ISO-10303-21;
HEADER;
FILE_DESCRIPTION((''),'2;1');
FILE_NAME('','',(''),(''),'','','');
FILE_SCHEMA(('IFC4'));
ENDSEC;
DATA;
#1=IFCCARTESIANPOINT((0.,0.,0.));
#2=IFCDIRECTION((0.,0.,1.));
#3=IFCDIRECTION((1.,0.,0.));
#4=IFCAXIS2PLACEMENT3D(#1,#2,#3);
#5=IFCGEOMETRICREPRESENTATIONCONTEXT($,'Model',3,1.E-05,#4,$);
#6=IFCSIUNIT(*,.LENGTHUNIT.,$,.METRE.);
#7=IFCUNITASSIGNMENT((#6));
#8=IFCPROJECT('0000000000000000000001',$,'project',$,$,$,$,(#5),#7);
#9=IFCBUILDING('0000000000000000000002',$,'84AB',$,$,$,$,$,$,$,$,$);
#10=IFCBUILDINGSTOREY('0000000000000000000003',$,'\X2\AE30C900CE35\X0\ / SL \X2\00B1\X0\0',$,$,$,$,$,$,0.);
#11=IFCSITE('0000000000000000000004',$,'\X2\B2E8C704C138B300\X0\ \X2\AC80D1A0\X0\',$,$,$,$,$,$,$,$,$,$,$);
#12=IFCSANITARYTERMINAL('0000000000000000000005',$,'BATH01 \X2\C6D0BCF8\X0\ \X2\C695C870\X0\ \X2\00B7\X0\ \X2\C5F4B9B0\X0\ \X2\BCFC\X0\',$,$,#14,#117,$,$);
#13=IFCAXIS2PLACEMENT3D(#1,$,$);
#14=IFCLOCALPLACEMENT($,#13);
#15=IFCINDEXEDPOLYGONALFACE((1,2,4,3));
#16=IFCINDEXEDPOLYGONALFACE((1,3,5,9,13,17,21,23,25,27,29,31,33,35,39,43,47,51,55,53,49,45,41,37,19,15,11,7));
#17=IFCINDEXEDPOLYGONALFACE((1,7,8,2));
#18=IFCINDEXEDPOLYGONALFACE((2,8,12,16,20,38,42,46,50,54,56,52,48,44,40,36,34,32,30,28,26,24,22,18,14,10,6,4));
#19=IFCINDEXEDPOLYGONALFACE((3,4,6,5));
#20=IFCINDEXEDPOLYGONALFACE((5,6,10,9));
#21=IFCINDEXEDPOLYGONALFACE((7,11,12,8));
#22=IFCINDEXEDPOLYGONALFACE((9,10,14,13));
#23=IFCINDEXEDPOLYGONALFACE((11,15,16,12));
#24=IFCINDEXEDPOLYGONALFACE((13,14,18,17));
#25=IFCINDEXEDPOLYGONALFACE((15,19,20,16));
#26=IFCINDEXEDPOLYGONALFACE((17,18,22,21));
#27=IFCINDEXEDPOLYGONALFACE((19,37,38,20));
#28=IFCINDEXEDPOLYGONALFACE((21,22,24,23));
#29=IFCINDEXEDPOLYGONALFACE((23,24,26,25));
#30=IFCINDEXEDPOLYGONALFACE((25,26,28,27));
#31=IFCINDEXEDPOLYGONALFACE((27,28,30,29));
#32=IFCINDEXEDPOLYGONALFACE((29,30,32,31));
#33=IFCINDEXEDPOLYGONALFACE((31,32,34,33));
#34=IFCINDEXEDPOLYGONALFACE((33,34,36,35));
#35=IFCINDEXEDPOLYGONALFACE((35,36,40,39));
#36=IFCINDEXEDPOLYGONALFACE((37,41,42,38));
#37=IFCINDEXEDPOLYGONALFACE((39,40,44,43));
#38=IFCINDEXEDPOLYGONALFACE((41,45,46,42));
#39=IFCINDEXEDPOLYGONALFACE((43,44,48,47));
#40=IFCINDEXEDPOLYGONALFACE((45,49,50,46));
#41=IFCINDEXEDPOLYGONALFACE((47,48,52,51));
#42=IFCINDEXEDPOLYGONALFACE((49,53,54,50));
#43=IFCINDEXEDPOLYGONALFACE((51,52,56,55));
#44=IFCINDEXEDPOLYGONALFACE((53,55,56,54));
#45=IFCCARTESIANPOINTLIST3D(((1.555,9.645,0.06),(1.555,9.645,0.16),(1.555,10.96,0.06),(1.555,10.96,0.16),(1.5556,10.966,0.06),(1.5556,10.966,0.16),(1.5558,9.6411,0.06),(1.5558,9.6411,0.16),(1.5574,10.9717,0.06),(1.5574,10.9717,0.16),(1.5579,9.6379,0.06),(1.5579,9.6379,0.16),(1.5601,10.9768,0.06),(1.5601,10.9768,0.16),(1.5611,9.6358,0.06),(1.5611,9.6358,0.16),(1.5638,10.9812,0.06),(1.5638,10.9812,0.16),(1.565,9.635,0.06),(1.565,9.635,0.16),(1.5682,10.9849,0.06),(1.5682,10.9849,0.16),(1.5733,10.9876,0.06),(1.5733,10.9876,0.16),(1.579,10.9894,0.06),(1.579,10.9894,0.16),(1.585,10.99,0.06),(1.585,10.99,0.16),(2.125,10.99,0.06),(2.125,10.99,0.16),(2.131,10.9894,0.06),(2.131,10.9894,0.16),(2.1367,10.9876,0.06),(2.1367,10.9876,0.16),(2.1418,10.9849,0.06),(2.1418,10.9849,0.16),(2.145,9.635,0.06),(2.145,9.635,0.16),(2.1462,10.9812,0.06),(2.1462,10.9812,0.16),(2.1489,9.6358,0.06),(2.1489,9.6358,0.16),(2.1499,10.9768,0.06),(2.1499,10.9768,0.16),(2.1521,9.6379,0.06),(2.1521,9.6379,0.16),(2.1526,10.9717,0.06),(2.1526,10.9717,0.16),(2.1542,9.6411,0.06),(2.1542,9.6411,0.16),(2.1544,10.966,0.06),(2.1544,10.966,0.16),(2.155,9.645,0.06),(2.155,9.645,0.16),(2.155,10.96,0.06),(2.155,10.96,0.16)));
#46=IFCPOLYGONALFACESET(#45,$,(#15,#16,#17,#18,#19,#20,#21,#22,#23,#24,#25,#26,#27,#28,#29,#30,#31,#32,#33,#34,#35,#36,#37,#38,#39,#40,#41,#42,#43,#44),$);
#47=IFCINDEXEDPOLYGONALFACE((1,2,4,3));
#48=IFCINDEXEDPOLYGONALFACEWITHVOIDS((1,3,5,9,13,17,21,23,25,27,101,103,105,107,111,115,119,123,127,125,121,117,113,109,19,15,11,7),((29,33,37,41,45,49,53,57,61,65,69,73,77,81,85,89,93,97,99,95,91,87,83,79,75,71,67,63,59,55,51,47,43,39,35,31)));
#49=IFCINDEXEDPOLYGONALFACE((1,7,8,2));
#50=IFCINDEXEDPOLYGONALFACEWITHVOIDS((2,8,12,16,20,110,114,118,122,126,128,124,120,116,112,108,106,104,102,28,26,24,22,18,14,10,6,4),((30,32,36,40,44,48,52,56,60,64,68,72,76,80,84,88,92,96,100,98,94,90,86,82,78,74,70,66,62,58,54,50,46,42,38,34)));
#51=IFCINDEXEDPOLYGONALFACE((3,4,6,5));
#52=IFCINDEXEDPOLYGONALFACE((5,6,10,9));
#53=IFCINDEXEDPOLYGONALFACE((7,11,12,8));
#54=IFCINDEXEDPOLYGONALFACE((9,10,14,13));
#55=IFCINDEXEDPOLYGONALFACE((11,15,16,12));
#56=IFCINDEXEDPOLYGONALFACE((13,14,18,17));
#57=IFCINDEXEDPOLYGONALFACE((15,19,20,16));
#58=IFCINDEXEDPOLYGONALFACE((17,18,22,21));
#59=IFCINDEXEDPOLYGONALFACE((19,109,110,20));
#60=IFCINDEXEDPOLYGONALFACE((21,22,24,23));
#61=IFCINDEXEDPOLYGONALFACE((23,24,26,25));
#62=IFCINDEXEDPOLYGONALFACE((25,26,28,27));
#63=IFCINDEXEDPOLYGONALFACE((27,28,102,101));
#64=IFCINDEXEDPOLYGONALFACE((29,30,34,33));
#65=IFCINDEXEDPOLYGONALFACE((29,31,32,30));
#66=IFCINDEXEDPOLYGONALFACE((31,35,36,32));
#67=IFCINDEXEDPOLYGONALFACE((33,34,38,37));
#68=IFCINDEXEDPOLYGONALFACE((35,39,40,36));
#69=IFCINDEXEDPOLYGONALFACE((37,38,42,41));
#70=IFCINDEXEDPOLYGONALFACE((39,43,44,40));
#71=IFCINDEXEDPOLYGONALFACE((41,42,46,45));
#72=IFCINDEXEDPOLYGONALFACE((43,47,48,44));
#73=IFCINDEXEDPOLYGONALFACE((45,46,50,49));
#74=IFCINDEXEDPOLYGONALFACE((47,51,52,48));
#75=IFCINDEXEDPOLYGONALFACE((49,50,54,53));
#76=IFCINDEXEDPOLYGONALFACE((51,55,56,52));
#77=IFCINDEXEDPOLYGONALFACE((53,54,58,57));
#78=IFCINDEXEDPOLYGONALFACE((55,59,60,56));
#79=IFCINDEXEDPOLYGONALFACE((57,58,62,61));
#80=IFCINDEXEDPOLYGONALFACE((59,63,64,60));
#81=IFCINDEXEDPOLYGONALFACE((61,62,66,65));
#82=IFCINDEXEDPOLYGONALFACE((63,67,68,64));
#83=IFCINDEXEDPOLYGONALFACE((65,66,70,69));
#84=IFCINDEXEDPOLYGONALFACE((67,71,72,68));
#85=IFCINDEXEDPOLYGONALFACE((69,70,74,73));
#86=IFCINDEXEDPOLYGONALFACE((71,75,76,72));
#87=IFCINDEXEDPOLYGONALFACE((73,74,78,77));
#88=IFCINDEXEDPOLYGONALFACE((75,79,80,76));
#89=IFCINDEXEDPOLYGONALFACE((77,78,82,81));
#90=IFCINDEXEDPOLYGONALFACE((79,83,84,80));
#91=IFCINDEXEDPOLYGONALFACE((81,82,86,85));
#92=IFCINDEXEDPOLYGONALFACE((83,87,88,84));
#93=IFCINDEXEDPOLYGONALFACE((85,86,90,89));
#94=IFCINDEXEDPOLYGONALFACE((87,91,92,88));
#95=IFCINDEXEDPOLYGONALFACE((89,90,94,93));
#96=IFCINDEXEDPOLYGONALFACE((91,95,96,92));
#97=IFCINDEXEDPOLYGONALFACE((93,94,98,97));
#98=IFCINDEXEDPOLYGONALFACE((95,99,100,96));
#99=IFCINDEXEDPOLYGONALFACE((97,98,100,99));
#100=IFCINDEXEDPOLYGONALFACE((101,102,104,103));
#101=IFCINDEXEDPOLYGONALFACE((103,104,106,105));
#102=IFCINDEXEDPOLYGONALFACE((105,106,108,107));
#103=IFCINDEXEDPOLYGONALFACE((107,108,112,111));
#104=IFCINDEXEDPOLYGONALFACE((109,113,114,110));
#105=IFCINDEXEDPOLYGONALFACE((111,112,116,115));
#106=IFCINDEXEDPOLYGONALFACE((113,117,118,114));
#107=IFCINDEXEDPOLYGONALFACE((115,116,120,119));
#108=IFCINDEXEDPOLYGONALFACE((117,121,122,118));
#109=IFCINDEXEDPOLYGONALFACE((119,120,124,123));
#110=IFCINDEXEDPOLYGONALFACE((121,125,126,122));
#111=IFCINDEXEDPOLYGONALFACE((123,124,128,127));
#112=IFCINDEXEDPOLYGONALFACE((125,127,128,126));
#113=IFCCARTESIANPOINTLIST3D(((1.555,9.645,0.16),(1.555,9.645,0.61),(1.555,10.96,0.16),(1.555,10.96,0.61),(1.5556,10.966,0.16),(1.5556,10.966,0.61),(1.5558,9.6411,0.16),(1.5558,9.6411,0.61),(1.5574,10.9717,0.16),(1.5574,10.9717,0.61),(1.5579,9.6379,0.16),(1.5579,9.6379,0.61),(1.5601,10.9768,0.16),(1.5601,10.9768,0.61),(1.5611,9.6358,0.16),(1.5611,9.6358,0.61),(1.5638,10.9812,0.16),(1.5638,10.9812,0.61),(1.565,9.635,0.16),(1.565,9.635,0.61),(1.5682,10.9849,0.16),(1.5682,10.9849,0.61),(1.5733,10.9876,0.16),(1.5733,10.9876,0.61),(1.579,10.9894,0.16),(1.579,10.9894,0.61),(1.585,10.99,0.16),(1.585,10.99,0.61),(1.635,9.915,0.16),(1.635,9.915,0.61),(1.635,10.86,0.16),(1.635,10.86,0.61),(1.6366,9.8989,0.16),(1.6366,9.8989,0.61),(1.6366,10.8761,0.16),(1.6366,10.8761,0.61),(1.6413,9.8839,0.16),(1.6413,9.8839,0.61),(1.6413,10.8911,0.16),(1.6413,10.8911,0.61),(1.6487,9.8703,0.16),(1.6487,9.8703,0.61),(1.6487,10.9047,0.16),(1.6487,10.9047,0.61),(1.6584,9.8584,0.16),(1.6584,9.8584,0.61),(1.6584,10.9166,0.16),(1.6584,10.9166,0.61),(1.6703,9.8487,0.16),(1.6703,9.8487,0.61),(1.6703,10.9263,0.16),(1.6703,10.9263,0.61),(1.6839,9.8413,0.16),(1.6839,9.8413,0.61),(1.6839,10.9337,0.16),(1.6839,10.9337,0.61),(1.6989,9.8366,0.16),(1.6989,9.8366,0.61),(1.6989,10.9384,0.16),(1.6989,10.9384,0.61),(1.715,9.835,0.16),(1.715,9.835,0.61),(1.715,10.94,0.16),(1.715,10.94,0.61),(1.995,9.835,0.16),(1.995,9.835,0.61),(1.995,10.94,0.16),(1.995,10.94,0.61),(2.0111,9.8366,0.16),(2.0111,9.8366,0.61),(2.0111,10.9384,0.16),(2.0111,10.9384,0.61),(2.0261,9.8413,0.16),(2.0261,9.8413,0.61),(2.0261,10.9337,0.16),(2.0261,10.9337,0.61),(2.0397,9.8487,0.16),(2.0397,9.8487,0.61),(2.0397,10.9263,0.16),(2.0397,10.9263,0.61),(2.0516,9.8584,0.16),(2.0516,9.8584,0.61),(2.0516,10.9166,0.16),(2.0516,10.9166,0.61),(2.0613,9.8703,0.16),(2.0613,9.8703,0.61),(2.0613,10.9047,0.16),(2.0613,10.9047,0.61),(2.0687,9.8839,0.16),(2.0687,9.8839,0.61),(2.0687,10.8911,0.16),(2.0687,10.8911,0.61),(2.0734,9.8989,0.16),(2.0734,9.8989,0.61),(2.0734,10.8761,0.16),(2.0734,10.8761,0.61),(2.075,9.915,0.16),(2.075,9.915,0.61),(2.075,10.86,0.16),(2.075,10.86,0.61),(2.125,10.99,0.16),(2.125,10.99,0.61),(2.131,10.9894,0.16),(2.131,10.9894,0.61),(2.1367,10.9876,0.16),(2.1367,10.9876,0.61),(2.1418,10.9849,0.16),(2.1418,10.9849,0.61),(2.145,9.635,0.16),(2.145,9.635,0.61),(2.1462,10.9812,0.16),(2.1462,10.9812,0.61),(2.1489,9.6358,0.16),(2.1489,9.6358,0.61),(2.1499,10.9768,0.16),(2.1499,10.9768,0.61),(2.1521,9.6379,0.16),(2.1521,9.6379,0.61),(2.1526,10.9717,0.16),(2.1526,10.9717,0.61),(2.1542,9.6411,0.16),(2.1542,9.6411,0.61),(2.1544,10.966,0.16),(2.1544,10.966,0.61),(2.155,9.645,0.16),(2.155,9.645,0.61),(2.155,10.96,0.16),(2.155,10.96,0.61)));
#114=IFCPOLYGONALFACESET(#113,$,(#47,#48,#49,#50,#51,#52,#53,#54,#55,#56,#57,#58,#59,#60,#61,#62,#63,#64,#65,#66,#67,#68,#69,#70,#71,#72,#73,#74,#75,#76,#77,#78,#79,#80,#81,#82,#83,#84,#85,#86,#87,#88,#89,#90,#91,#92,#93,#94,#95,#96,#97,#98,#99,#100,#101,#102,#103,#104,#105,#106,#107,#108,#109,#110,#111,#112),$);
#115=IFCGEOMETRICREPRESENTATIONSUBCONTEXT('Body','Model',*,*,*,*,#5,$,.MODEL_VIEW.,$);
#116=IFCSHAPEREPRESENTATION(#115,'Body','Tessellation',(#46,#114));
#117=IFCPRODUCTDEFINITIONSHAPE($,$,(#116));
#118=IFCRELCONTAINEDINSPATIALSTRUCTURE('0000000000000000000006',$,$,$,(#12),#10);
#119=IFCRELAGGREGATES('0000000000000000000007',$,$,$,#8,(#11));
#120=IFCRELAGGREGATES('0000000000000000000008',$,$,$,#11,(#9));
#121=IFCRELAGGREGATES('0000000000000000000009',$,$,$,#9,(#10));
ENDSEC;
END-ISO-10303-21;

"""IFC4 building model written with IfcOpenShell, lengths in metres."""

from ifc_helpers import new_model, si_unit, frame, origin_with_axes, place, context, subcontext, project, spatial, polyline, outline, extrude, element, save


model = new_model("IFC4")

# Units and contexts
model_context = context("Model", 3, precision=1e-05, world=origin_with_axes())
body_context = subcontext(model_context, "Body", "Model", "MODEL_VIEW")
ifc_project = project(units=[si_unit("LENGTHUNIT", "METRE")], contexts=[model_context])

# Site, building, storey
site = spatial("IfcSite", under=ifc_project, Name="단위세대 검토")
building = spatial("IfcBuilding", under=site, Name="84AB")
storey = spatial("IfcBuildingStorey", under=building, Name="기준층 / SL ±0", Elevation=0.0)

# Sanitary terminal
sanitary_terminal_1_placement = place(None, origin_with_axes())
element("IfcSanitaryTerminal", 1, at=sanitary_terminal_1_placement, inside=storey, Name="BATH01 원본 욕조 · 열린 볼", context=body_context, shape_type="SweptSolid", body=[
    extrude(outline(polyline([(1.585, 10.99), (1.579, 10.9894), (1.5733, 10.9876), (1.5682, 10.9849), (1.5638, 10.9812), (1.5601, 10.9768), (1.5574, 10.9717), (1.5556, 10.966), (1.555, 10.96), (1.555, 9.645), (1.5558, 9.6411), (1.5579, 9.6379), (1.5611, 9.6358), (1.565, 9.635), (2.145, 9.635), (2.1489, 9.6358), (2.1521, 9.6379), (2.1542, 9.6411), (2.155, 9.645), (2.155, 10.96), (2.1544, 10.966), (2.1526, 10.9717), (2.1499, 10.9768), (2.1462, 10.9812), (2.1418, 10.9849), (2.1367, 10.9876), (2.131, 10.9894), (2.125, 10.99), (1.585, 10.99)])), frame((0.0, 0.0, 0.06)), (0.0, 0.0, 1.0), 0.1),
    extrude(outline(polyline([(2.125, 10.99), (2.131, 10.9894), (2.1367, 10.9876), (2.1418, 10.9849), (2.1462, 10.9812), (2.1499, 10.9768), (2.1526, 10.9717), (2.1544, 10.966), (2.155, 10.96), (2.155, 9.645), (2.1542, 9.6411), (2.1521, 9.6379), (2.1489, 9.6358), (2.145, 9.635), (1.565, 9.635), (1.5611, 9.6358), (1.5579, 9.6379), (1.5558, 9.6411), (1.555, 9.645), (1.555, 10.96), (1.5556, 10.966), (1.5574, 10.9717), (1.5601, 10.9768), (1.5638, 10.9812), (1.5682, 10.9849), (1.5733, 10.9876), (1.579, 10.9894), (1.585, 10.99), (2.125, 10.99)]), holes=[polyline([(1.715, 10.94), (1.6989, 10.9384), (1.6839, 10.9337), (1.6703, 10.9263), (1.6584, 10.9166), (1.6487, 10.9047), (1.6413, 10.8911), (1.6366, 10.8761), (1.635, 10.86), (1.635, 9.915), (1.6366, 9.8989), (1.6413, 9.8839), (1.6487, 9.8703), (1.6584, 9.8584), (1.6703, 9.8487), (1.6839, 9.8413), (1.6989, 9.8366), (1.715, 9.835), (1.995, 9.835), (2.0111, 9.8366), (2.0261, 9.8413), (2.0397, 9.8487), (2.0516, 9.8584), (2.0613, 9.8703), (2.0687, 9.8839), (2.0734, 9.8989), (2.075, 9.915), (2.075, 10.86), (2.0734, 10.8761), (2.0687, 10.8911), (2.0613, 10.9047), (2.0516, 10.9166), (2.0397, 10.9263), (2.0261, 10.9337), (2.0111, 10.9384), (1.995, 10.94), (1.715, 10.94)])]), frame((0.0, 0.0, 0.16)), (0.0, 0.0, 1.0), 0.45),
])

save(model, "model.ifc")
